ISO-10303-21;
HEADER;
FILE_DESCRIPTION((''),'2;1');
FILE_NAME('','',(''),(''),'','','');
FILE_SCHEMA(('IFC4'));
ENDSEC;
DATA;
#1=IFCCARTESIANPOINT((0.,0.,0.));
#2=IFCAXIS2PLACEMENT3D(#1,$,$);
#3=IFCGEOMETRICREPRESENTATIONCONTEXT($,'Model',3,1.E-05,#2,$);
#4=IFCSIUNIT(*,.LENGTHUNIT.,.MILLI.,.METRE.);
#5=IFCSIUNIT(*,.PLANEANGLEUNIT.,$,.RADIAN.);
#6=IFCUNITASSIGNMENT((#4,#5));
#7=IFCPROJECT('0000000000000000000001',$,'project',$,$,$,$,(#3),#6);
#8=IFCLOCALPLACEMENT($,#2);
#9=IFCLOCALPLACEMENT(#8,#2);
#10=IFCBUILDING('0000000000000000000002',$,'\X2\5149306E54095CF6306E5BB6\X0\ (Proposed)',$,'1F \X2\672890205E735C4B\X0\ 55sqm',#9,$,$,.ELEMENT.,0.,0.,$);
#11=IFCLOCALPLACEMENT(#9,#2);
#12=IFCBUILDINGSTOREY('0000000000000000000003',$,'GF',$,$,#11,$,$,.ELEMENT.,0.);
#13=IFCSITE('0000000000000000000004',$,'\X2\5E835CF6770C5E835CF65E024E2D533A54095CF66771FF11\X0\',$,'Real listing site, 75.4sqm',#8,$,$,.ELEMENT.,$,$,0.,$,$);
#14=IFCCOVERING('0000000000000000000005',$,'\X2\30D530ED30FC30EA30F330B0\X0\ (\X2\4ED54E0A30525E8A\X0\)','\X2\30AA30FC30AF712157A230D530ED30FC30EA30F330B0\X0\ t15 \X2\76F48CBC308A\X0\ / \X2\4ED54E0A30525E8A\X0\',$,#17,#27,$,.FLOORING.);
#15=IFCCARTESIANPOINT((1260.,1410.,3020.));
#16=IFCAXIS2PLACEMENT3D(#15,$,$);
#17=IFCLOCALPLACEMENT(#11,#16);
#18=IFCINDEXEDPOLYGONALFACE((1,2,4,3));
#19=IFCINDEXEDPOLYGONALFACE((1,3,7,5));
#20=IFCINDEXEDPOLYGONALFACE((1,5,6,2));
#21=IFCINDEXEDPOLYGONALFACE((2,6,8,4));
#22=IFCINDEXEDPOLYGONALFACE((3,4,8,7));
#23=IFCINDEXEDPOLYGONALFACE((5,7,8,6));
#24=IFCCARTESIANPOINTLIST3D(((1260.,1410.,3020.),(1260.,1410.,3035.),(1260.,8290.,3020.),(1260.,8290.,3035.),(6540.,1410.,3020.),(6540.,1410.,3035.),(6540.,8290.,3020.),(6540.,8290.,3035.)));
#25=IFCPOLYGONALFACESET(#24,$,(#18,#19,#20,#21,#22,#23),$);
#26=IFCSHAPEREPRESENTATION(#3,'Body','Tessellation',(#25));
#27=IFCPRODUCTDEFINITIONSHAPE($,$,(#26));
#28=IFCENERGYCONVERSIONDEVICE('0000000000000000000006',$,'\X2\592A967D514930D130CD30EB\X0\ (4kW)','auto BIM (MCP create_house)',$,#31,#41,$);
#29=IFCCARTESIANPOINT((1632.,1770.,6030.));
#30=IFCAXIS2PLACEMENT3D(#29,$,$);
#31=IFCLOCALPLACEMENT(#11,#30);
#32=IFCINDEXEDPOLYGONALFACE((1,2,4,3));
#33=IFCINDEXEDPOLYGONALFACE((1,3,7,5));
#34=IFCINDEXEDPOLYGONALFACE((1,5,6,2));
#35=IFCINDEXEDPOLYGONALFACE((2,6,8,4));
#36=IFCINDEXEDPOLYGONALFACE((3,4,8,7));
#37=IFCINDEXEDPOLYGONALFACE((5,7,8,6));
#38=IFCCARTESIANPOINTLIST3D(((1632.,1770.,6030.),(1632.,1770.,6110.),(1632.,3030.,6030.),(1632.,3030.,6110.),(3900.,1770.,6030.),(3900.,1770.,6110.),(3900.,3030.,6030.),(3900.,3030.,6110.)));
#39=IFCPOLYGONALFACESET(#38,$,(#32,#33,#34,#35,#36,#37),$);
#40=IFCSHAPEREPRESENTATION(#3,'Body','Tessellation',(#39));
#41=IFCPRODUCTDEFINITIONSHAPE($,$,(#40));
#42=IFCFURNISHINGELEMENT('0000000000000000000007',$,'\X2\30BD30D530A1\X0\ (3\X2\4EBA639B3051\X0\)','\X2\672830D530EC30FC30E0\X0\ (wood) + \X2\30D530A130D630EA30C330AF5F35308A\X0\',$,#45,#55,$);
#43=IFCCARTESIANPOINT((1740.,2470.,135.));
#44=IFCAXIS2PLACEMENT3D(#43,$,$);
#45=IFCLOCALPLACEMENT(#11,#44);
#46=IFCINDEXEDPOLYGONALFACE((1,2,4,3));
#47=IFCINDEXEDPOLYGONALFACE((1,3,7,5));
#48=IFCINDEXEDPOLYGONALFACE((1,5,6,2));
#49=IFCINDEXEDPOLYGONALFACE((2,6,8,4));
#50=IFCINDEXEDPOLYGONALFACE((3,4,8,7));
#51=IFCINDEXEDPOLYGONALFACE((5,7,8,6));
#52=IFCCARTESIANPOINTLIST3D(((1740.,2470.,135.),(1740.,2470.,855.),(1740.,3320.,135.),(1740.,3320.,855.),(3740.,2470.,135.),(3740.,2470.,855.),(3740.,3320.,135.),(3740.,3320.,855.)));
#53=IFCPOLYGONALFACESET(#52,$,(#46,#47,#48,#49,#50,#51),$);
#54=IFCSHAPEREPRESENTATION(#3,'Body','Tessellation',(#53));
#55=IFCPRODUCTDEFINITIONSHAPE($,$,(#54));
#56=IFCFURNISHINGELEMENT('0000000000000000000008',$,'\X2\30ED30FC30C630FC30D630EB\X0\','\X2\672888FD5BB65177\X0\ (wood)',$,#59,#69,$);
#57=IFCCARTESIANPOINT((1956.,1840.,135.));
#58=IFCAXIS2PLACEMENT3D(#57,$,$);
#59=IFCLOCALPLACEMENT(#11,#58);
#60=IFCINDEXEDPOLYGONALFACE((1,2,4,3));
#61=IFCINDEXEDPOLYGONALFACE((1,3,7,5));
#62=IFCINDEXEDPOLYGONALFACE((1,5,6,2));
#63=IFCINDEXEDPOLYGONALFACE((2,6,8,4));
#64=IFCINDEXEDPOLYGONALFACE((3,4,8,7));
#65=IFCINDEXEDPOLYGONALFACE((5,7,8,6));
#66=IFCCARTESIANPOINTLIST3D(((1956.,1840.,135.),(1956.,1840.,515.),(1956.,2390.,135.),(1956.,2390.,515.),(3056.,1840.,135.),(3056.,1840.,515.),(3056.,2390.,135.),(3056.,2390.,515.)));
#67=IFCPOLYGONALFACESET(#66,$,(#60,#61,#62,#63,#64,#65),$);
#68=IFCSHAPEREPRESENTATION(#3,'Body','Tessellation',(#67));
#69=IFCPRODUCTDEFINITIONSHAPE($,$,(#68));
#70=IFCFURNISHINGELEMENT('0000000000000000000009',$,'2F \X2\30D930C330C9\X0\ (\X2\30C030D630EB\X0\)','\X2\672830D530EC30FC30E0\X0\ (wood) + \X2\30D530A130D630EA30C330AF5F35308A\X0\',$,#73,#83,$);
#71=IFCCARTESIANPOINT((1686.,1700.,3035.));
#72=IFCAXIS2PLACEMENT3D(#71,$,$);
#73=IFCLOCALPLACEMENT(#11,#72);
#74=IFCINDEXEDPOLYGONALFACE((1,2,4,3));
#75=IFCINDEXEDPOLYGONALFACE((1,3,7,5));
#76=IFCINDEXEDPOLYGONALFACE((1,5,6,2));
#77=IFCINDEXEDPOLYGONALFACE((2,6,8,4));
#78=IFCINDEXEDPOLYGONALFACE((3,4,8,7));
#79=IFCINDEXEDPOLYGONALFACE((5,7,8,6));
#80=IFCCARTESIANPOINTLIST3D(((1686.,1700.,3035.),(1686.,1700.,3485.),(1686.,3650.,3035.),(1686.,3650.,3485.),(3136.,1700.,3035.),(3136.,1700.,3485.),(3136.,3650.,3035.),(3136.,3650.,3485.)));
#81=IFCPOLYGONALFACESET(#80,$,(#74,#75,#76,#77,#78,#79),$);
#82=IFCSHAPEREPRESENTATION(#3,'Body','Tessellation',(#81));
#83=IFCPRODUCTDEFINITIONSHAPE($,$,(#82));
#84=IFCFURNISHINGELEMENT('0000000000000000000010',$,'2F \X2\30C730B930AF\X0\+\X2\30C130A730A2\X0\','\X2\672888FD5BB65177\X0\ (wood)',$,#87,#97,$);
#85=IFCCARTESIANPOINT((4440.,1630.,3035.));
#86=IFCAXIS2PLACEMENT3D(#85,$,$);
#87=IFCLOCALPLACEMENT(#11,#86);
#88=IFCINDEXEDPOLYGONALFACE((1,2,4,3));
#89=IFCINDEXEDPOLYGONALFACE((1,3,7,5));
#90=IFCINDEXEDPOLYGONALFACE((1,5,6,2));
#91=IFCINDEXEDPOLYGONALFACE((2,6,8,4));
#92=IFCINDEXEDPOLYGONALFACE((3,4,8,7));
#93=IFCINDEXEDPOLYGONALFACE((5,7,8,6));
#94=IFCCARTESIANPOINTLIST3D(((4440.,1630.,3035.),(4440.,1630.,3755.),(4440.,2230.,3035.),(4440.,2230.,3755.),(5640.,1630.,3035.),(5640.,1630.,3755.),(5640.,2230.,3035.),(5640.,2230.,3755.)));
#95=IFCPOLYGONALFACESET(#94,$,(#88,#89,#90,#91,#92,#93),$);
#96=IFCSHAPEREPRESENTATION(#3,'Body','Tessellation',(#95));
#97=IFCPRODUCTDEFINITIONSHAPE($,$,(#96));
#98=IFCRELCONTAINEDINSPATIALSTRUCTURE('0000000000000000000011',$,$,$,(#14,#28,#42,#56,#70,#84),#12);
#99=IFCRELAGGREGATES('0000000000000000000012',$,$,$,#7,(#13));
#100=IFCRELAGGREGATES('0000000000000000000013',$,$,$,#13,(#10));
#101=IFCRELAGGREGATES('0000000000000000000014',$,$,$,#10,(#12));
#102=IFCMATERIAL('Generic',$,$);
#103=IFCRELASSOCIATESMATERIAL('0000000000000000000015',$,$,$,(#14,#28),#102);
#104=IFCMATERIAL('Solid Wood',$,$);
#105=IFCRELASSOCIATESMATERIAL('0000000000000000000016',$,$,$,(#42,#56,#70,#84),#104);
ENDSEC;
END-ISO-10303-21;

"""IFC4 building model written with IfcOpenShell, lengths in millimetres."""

from ifc_helpers import new_model, si_unit, frame, frame_2d, origin, place, context, project, spatial, rectangle, extrude, material, element, save


model = new_model("IFC4")

# Units and contexts
model_context = context("Model", 3, precision=1e-05, world=origin())
ifc_project = project(units=[si_unit("LENGTHUNIT", "METRE", prefix="MILLI"), si_unit("PLANEANGLEUNIT", "RADIAN")], contexts=[model_context])

# Site, building, storey
site_placement = place(None, origin())
site = spatial("IfcSite", under=ifc_project, at=site_placement, Name="広島県広島市中区吉島東１", ObjectType="Real listing site, 75.4sqm", CompositionType="ELEMENT", RefElevation=0.0)
building_placement = place(site_placement, origin())
building = spatial("IfcBuilding", under=site, at=building_placement, Name="光の吉島の家 (Proposed)", ObjectType="1F 木造平屋 55sqm", CompositionType="ELEMENT", ElevationOfRefHeight=0.0, ElevationOfTerrain=0.0)
storey_placement = place(building_placement, origin())
storey = spatial("IfcBuildingStorey", under=building, at=storey_placement, Name="GF", CompositionType="ELEMENT", Elevation=0.0)

# Shared definitions
ifc_material_1 = material(Name="Solid Wood")

# Shared definitions
ifc_material_2 = material(Name="Generic")

# Covering
covering_placement = place(storey_placement, frame((1260.0, 1410.0, 3020.0)))
element("IfcCovering", 1, at=covering_placement, inside=storey, material=ifc_material_2, Name="フローリング (仕上げ床)", Description="オーク無垢フローリング t15 直貼り / 仕上げ床", PredefinedType="FLOORING", context=model_context, shape_type="SweptSolid", body=[
    extrude(rectangle(XDim=5280.0, YDim=6880.0, at=frame_2d((2640.0, 3440.0))), frame((1260.0, 1410.0, 3020.0)), (0.0, 0.0, 1.0), 15.0),
])

# Energy conversion device
energy_conversion_device_placement = place(storey_placement, frame((1632.0, 1770.0, 6030.0)))
element("IfcEnergyConversionDevice", 2, at=energy_conversion_device_placement, inside=storey, material=ifc_material_2, Name="太陽光パネル (4kW)", Description="auto BIM (MCP create_house)", context=model_context, shape_type="SweptSolid", body=[
    extrude(rectangle(XDim=2268.0, YDim=1260.0, at=frame_2d((1134.0, 630.0))), frame((1632.0, 1770.0, 6030.0)), (0.0, 0.0, 1.0), 80.0),
])

# Furnishing elements
furnishing_1_placement = place(storey_placement, frame((1740.0, 2470.0, 135.0)))
element("IfcFurnishingElement", 3, at=furnishing_1_placement, inside=storey, material=ifc_material_1, Name="ソファ (3人掛け)", Description="木フレーム (wood) + ファブリック張り", context=model_context, shape_type="SweptSolid", body=[
    extrude(rectangle(XDim=2000.0, YDim=850.0, at=frame_2d((1000.0, 425.0))), frame((1740.0, 2470.0, 135.0)), (0.0, 0.0, 1.0), 720.0),
])
furnishing_2_placement = place(storey_placement, frame((1956.0, 1840.0, 135.0)))
element("IfcFurnishingElement", 4, at=furnishing_2_placement, inside=storey, material=ifc_material_1, Name="ローテーブル", Description="木製家具 (wood)", context=model_context, shape_type="SweptSolid", body=[
    extrude(rectangle(XDim=1100.0, YDim=550.0, at=frame_2d((550.0, 275.0))), frame((1956.0, 1840.0, 135.0)), (0.0, 0.0, 1.0), 380.0),
])
furnishing_3_placement = place(storey_placement, frame((1686.0, 1700.0, 3035.0)))
element("IfcFurnishingElement", 5, at=furnishing_3_placement, inside=storey, material=ifc_material_1, Name="2F ベッド (ダブル)", Description="木フレーム (wood) + ファブリック張り", context=model_context, shape_type="SweptSolid", body=[
    extrude(rectangle(XDim=1450.0, YDim=1950.0, at=frame_2d((725.0, 975.0))), frame((1686.0, 1700.0, 3035.0)), (0.0, 0.0, 1.0), 450.0),
])
furnishing_4_placement = place(storey_placement, frame((4440.0, 1630.0, 3035.0)))
element("IfcFurnishingElement", 6, at=furnishing_4_placement, inside=storey, material=ifc_material_1, Name="2F デスク+チェア", Description="木製家具 (wood)", context=model_context, shape_type="SweptSolid", body=[
    extrude(rectangle(XDim=1200.0, YDim=600.0, at=frame_2d((600.0, 300.0))), frame((4440.0, 1630.0, 3035.0)), (0.0, 0.0, 1.0), 720.0),
])

save(model, "model.ifc")
